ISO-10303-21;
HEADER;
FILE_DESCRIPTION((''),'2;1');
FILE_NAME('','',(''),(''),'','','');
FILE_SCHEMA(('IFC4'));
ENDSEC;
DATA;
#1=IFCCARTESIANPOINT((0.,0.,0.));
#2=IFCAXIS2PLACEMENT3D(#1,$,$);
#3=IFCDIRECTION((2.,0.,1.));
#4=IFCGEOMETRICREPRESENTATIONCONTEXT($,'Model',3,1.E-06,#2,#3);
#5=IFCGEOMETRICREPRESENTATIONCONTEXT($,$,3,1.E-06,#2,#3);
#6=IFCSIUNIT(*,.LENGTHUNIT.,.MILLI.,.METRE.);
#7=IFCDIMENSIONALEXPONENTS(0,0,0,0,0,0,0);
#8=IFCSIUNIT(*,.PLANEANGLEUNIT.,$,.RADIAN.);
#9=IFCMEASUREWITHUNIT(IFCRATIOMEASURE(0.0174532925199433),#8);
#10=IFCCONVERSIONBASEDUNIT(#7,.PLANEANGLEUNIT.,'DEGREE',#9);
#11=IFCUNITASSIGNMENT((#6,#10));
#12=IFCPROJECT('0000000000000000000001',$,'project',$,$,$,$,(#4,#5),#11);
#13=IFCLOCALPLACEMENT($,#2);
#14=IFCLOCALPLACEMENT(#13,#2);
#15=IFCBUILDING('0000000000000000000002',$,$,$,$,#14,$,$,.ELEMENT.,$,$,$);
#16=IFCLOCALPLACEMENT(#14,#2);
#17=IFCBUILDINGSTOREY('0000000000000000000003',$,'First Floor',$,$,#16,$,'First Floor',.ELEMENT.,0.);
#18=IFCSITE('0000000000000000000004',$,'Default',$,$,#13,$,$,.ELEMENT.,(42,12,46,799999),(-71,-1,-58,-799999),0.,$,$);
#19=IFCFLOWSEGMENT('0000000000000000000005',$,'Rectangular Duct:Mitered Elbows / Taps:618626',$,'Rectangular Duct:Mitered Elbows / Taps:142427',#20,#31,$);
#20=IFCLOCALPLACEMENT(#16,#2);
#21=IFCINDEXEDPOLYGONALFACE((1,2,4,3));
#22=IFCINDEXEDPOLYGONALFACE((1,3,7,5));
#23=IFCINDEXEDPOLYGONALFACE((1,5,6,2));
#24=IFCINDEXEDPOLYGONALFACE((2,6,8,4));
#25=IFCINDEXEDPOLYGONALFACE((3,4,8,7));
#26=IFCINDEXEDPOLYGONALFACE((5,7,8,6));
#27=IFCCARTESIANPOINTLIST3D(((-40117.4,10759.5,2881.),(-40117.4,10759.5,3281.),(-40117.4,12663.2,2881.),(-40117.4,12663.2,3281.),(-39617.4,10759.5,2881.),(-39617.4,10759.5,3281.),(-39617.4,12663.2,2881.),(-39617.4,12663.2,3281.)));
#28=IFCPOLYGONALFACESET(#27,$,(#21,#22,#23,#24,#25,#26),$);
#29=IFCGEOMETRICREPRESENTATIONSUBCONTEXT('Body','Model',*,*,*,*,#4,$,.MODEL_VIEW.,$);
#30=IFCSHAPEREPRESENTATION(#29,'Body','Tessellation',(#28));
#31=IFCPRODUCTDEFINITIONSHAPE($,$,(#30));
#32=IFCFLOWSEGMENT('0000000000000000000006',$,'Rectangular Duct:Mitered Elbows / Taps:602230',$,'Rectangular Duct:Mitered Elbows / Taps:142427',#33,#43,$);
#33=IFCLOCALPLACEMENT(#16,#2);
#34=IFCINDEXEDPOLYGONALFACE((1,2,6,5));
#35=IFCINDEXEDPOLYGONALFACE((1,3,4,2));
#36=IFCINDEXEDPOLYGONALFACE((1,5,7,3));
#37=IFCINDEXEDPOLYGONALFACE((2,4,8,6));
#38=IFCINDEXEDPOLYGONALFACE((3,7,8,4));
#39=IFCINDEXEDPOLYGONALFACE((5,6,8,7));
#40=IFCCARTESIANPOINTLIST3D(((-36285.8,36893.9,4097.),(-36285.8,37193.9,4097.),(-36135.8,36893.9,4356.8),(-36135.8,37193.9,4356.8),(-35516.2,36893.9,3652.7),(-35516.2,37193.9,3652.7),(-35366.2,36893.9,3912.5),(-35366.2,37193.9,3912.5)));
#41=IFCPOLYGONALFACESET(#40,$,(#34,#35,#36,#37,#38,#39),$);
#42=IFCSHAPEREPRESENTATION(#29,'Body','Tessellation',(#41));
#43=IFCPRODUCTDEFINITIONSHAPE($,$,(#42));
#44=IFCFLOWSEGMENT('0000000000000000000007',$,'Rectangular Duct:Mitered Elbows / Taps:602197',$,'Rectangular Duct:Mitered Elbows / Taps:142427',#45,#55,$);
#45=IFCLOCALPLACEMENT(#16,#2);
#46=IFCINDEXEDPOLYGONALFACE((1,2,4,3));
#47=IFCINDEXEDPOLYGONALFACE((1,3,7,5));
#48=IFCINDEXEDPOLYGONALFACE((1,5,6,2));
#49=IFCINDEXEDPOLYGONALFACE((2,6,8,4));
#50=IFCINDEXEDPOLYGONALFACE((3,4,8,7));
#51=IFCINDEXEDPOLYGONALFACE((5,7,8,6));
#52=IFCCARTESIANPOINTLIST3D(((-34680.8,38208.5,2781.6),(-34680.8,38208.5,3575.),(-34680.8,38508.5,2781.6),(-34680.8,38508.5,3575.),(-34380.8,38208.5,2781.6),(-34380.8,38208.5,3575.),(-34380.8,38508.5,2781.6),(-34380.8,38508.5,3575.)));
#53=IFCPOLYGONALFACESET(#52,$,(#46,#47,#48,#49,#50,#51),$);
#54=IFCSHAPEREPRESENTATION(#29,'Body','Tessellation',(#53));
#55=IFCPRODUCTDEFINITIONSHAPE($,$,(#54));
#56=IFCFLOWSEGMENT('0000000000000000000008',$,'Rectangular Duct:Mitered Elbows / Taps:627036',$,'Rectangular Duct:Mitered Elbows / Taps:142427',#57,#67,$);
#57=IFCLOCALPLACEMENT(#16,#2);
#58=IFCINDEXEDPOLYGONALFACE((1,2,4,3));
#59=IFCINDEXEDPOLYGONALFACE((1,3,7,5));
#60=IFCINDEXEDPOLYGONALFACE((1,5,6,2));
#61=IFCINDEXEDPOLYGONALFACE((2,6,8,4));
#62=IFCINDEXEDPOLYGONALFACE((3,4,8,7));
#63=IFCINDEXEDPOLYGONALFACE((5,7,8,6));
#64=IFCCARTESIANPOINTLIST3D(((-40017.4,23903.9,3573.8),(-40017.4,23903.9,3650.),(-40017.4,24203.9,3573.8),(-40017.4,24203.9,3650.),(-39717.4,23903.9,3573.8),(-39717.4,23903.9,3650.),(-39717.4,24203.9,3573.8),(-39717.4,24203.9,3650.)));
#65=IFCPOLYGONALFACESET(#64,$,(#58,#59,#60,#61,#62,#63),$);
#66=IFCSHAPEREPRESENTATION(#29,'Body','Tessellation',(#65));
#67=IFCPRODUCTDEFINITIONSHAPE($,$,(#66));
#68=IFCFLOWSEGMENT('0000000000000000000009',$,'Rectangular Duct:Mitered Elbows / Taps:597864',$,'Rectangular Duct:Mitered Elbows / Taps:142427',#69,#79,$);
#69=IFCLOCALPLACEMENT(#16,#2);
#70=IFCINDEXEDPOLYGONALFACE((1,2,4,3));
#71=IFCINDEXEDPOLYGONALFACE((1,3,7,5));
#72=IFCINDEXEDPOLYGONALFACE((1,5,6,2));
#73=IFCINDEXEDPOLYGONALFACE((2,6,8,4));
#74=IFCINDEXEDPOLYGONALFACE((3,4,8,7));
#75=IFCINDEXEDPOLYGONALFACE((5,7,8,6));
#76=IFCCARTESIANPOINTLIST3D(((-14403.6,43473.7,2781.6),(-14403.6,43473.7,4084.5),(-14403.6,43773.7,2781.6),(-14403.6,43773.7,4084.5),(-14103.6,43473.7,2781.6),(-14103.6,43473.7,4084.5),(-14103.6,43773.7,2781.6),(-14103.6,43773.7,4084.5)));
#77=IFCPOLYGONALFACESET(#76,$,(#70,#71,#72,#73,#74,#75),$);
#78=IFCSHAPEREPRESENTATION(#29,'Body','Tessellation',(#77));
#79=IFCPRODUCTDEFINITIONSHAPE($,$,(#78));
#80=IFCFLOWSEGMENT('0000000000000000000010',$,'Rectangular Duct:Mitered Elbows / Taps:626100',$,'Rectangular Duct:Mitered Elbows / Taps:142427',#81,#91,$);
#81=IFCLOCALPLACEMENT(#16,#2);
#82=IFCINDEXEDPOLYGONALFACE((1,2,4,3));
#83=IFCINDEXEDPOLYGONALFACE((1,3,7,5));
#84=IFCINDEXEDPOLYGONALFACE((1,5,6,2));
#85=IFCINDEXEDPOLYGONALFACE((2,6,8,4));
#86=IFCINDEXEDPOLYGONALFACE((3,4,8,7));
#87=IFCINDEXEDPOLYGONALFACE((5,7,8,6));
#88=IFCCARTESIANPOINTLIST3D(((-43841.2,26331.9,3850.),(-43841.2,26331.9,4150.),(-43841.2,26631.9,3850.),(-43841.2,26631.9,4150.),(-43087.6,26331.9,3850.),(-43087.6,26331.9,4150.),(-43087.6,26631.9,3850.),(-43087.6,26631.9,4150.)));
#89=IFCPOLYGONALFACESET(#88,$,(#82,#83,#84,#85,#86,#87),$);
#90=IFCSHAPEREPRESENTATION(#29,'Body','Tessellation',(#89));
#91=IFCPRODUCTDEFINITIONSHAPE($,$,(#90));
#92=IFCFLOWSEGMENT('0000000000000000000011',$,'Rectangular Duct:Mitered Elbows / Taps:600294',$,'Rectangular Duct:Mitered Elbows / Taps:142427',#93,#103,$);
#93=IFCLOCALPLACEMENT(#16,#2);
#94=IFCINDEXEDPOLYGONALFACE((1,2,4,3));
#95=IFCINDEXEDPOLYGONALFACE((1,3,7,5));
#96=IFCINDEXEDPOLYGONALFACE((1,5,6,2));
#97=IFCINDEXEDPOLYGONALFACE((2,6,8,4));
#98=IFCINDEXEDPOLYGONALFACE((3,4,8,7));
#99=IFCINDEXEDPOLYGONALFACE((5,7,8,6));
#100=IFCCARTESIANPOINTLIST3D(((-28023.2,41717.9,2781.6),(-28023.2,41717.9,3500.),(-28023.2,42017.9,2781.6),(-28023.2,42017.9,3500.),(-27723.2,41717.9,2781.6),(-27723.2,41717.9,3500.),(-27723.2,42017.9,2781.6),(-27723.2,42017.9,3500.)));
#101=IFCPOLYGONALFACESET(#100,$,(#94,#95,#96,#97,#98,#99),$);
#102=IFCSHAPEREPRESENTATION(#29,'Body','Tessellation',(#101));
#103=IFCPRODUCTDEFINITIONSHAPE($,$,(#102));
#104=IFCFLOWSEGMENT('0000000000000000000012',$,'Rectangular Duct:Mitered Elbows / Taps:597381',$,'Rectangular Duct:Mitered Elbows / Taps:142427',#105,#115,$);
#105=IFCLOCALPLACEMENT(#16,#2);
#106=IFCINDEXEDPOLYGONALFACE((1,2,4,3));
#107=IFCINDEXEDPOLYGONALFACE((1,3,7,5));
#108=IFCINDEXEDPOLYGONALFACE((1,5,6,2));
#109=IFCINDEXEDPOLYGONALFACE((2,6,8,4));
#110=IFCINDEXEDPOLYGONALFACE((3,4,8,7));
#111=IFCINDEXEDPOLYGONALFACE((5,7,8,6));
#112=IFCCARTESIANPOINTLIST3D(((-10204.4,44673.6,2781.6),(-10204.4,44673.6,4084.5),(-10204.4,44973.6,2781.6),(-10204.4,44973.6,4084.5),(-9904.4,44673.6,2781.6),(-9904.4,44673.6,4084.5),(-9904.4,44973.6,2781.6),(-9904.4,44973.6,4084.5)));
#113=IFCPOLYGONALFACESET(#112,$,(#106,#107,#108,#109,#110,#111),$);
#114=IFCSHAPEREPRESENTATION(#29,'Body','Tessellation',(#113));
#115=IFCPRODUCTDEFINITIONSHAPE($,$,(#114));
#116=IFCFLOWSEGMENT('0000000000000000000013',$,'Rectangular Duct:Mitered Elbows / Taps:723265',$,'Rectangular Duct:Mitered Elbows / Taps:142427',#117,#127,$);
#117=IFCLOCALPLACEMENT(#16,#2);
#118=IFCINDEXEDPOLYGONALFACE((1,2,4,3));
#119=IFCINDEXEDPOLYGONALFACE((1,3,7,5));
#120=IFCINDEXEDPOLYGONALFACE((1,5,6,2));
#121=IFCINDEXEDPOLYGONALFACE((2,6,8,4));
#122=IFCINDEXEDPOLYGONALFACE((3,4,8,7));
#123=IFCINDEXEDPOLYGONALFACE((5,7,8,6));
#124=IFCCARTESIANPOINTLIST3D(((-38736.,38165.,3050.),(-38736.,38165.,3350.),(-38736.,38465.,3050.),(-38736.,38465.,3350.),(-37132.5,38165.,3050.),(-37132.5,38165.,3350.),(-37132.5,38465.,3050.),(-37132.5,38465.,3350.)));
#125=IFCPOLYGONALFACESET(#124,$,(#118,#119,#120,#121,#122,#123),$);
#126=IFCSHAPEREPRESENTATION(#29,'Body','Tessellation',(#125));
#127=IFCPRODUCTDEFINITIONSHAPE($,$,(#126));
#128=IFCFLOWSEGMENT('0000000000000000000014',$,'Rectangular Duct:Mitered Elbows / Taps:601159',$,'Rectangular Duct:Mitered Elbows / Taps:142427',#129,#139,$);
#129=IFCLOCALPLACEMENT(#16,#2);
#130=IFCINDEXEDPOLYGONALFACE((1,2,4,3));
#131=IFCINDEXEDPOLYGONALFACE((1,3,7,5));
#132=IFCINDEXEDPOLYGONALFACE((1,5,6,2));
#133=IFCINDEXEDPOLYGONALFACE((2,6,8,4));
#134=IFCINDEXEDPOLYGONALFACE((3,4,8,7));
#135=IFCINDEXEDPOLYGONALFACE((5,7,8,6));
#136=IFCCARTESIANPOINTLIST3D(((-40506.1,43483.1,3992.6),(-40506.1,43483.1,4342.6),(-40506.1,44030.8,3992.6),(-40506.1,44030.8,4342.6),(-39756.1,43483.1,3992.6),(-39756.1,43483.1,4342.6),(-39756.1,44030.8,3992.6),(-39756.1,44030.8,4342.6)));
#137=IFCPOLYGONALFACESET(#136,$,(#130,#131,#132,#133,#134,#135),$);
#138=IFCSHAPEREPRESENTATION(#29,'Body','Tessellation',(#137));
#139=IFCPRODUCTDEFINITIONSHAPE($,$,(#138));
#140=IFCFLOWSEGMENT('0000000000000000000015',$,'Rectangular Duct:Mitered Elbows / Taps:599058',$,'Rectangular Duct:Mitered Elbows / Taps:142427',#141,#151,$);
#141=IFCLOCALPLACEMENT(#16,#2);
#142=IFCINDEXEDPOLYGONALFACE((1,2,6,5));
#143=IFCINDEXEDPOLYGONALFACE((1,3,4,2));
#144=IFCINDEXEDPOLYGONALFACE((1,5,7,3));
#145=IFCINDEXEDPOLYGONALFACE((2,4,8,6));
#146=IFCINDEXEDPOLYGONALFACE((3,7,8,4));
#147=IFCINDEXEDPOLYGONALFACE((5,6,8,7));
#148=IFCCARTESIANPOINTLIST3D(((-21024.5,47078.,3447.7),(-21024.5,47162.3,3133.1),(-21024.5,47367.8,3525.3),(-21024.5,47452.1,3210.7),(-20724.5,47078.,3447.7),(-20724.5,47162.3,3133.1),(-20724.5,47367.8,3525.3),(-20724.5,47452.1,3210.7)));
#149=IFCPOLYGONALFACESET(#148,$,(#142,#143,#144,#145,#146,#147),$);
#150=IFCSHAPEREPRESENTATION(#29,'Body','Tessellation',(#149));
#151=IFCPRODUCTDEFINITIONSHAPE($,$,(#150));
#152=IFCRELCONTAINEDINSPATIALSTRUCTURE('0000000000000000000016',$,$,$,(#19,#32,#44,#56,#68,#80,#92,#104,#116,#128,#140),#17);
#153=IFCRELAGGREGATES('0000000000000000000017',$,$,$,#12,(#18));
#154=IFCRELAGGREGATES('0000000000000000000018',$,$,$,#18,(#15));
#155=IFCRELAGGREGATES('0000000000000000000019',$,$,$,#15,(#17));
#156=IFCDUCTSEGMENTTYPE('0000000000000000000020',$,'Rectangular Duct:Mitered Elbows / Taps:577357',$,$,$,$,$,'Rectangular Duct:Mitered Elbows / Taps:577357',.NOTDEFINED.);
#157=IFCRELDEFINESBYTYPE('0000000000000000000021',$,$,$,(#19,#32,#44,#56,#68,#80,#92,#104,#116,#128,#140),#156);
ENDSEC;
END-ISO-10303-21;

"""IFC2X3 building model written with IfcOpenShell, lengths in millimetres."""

from ifc_helpers import new_model, entity, si_unit, converted_unit, direction, frame, frame_2d, origin, origin_2d_with_axis, place, context, subcontext, project, spatial, rectangle, extrude, type_object, element, save


model = new_model("IFC2X3")

# Units and contexts
model_context = context("Model", 3, precision=1e-06, world=origin(), true_north=direction((2.0, 0.0, 1.0)))
context_of_model = context(None, 3, precision=1e-06, world=origin(), true_north=direction((2.0, 0.0, 1.0)))
body_context = subcontext(model_context, "Body", "Model", "MODEL_VIEW")
ifc_project = project(units=[si_unit("LENGTHUNIT", "METRE", prefix="MILLI"), converted_unit("PLANEANGLEUNIT", "DEGREE", entity("IfcRatioMeasure", 0.0174532925199433), si_unit("PLANEANGLEUNIT", "RADIAN"), dimensions=[0, 0, 0, 0, 0, 0, 0])], contexts=[model_context, context_of_model])

# Site, building, storey
site_placement = place(None, origin())
site = spatial("IfcSite", under=ifc_project, at=site_placement, Name="Default", CompositionType="ELEMENT", RefLatitude=(42, 12, 46, 799999), RefLongitude=(-71, -1, -58, -799999), RefElevation=0.0)
building_placement = place(site_placement, origin())
building = spatial("IfcBuilding", under=site, at=building_placement, CompositionType="ELEMENT")
storey_placement = place(building_placement, origin())
storey = spatial("IfcBuildingStorey", under=building, at=storey_placement, Name="First Floor", LongName="First Floor", CompositionType="ELEMENT", Elevation=0.0)

# Flow segments
duct_segment_type_1 = type_object("IfcDuctSegmentType", Name="Rectangular Duct:Mitered Elbows / Taps:577357", ElementType="Rectangular Duct:Mitered Elbows / Taps:577357", PredefinedType="NOTDEFINED")
flow_segment_1_placement = place(storey_placement, origin())
element("IfcFlowSegment", 1, at=flow_segment_1_placement, inside=storey, type_object=duct_segment_type_1, Name="Rectangular Duct:Mitered Elbows / Taps:618626", ObjectType="Rectangular Duct:Mitered Elbows / Taps:142427", context=body_context, shape_type="SweptSolid", body=[
    extrude(rectangle(XDim=1903.7, YDim=500.0, at=frame_2d((0.0, 0.0), x_axis=(1.0, 0.0))), frame((-39867.4, 11711.3, 2881.0), z_axis=(0.0, 0.0, 1.0), x_axis=(0.0, 1.0, 0.0)), (0.0, 0.0, 1.0), 400.0),
])
flow_segment_2_placement = place(storey_placement, origin())
element("IfcFlowSegment", 2, at=flow_segment_2_placement, inside=storey, type_object=duct_segment_type_1, Name="Rectangular Duct:Mitered Elbows / Taps:602230", ObjectType="Rectangular Duct:Mitered Elbows / Taps:142427", context=body_context, shape_type="SweptSolid", body=[
    extrude(rectangle(XDim=300.0, YDim=300.0, at=frame_2d((0.0, 0.0), x_axis=(0.0, 1.0))), frame((-36210.8, 37043.9, 4226.9), z_axis=(0.866025, 0.0, -0.5), x_axis=(0.0, 1.0, 0.0)), (0.0, 0.0, 1.0), 888.6),
])
flow_segment_3_placement = place(storey_placement, origin())
element("IfcFlowSegment", 3, at=flow_segment_3_placement, inside=storey, type_object=duct_segment_type_1, Name="Rectangular Duct:Mitered Elbows / Taps:602197", ObjectType="Rectangular Duct:Mitered Elbows / Taps:142427", context=body_context, shape_type="SweptSolid", body=[
    extrude(rectangle(XDim=300.0, YDim=300.0, at=origin_2d_with_axis()), frame((-34530.8, 38358.5, 2781.6), z_axis=(0.0, 0.0, 1.0), x_axis=(0.0, 1.0, 0.0)), (0.0, 0.0, 1.0), 793.4),
])
flow_segment_4_placement = place(storey_placement, origin())
element("IfcFlowSegment", 4, at=flow_segment_4_placement, inside=storey, type_object=duct_segment_type_1, Name="Rectangular Duct:Mitered Elbows / Taps:627036", ObjectType="Rectangular Duct:Mitered Elbows / Taps:142427", context=body_context, shape_type="SweptSolid", body=[
    extrude(rectangle(XDim=300.0, YDim=300.0, at=origin_2d_with_axis()), frame((-39867.4, 24053.9, 3573.8), z_axis=(0.0, 0.0, 1.0), x_axis=(-1.0, 0.0, 0.0)), (0.0, 0.0, 1.0), 76.2),
])
flow_segment_5_placement = place(storey_placement, origin())
element("IfcFlowSegment", 5, at=flow_segment_5_placement, inside=storey, type_object=duct_segment_type_1, Name="Rectangular Duct:Mitered Elbows / Taps:597864", ObjectType="Rectangular Duct:Mitered Elbows / Taps:142427", context=body_context, shape_type="SweptSolid", body=[
    extrude(rectangle(XDim=300.0, YDim=300.0, at=origin_2d_with_axis()), frame((-14253.6, 43623.7, 2781.6)), (0.0, 0.0, 1.0), 1302.9),
])
flow_segment_6_placement = place(storey_placement, origin())
element("IfcFlowSegment", 6, at=flow_segment_6_placement, inside=storey, type_object=duct_segment_type_1, Name="Rectangular Duct:Mitered Elbows / Taps:626100", ObjectType="Rectangular Duct:Mitered Elbows / Taps:142427", context=body_context, shape_type="SweptSolid", body=[
    extrude(rectangle(XDim=753.7, YDim=300.0, at=frame_2d((0.0, 0.0), x_axis=(1.0, 0.0))), frame((-43464.4, 26481.9, 3850.0)), (0.0, 0.0, 1.0), 300.0),
])
flow_segment_7_placement = place(storey_placement, origin())
element("IfcFlowSegment", 7, at=flow_segment_7_placement, inside=storey, type_object=duct_segment_type_1, Name="Rectangular Duct:Mitered Elbows / Taps:600294", ObjectType="Rectangular Duct:Mitered Elbows / Taps:142427", context=body_context, shape_type="SweptSolid", body=[
    extrude(rectangle(XDim=300.0, YDim=300.0, at=origin_2d_with_axis()), frame((-27873.2, 41867.9, 2781.6)), (0.0, 0.0, 1.0), 718.4),
])
flow_segment_8_placement = place(storey_placement, origin())
element("IfcFlowSegment", 8, at=flow_segment_8_placement, inside=storey, type_object=duct_segment_type_1, Name="Rectangular Duct:Mitered Elbows / Taps:597381", ObjectType="Rectangular Duct:Mitered Elbows / Taps:142427", context=body_context, shape_type="SweptSolid", body=[
    extrude(rectangle(XDim=300.0, YDim=300.0, at=origin_2d_with_axis()), frame((-10054.4, 44823.6, 2781.6), z_axis=(0.0, 0.0, 1.0), x_axis=(0.0, -1.0, 0.0)), (0.0, 0.0, 1.0), 1302.9),
])
flow_segment_9_placement = place(storey_placement, origin())
element("IfcFlowSegment", 9, at=flow_segment_9_placement, inside=storey, type_object=duct_segment_type_1, Name="Rectangular Duct:Mitered Elbows / Taps:723265", ObjectType="Rectangular Duct:Mitered Elbows / Taps:142427", context=body_context, shape_type="SweptSolid", body=[
    extrude(rectangle(XDim=1603.4, YDim=300.0, at=origin_2d_with_axis()), frame((-37934.2, 38315.0, 3050.0)), (0.0, 0.0, 1.0), 300.0),
])
flow_segment_10_placement = place(storey_placement, origin())
element("IfcFlowSegment", 10, at=flow_segment_10_placement, inside=storey, type_object=duct_segment_type_1, Name="Rectangular Duct:Mitered Elbows / Taps:601159", ObjectType="Rectangular Duct:Mitered Elbows / Taps:142427", context=body_context, shape_type="SweptSolid", body=[
    extrude(rectangle(XDim=547.7, YDim=750.0, at=frame_2d((0.0, 0.0), x_axis=(1.0, 0.0))), frame((-40131.1, 43757.0, 3992.6), z_axis=(0.0, 0.0, 1.0), x_axis=(0.0, -1.0, 0.0)), (0.0, 0.0, 1.0), 350.0),
])
flow_segment_11_placement = place(storey_placement, origin())
element("IfcFlowSegment", 11, at=flow_segment_11_placement, inside=storey, type_object=duct_segment_type_1, Name="Rectangular Duct:Mitered Elbows / Taps:599058", ObjectType="Rectangular Duct:Mitered Elbows / Taps:142427", context=body_context, shape_type="SweptSolid", body=[
    extrude(rectangle(XDim=300.0, YDim=300.0, at=frame_2d((0.0, 0.0), x_axis=(0.0, 1.0))), frame((-20874.5, 47307.2, 3171.9), z_axis=(0.0, -0.258819, 0.965926), x_axis=(-1.0, 0.0, 0.0)), (0.0, 0.0, 1.0), 325.7),
])

save(model, "model.ifc")
